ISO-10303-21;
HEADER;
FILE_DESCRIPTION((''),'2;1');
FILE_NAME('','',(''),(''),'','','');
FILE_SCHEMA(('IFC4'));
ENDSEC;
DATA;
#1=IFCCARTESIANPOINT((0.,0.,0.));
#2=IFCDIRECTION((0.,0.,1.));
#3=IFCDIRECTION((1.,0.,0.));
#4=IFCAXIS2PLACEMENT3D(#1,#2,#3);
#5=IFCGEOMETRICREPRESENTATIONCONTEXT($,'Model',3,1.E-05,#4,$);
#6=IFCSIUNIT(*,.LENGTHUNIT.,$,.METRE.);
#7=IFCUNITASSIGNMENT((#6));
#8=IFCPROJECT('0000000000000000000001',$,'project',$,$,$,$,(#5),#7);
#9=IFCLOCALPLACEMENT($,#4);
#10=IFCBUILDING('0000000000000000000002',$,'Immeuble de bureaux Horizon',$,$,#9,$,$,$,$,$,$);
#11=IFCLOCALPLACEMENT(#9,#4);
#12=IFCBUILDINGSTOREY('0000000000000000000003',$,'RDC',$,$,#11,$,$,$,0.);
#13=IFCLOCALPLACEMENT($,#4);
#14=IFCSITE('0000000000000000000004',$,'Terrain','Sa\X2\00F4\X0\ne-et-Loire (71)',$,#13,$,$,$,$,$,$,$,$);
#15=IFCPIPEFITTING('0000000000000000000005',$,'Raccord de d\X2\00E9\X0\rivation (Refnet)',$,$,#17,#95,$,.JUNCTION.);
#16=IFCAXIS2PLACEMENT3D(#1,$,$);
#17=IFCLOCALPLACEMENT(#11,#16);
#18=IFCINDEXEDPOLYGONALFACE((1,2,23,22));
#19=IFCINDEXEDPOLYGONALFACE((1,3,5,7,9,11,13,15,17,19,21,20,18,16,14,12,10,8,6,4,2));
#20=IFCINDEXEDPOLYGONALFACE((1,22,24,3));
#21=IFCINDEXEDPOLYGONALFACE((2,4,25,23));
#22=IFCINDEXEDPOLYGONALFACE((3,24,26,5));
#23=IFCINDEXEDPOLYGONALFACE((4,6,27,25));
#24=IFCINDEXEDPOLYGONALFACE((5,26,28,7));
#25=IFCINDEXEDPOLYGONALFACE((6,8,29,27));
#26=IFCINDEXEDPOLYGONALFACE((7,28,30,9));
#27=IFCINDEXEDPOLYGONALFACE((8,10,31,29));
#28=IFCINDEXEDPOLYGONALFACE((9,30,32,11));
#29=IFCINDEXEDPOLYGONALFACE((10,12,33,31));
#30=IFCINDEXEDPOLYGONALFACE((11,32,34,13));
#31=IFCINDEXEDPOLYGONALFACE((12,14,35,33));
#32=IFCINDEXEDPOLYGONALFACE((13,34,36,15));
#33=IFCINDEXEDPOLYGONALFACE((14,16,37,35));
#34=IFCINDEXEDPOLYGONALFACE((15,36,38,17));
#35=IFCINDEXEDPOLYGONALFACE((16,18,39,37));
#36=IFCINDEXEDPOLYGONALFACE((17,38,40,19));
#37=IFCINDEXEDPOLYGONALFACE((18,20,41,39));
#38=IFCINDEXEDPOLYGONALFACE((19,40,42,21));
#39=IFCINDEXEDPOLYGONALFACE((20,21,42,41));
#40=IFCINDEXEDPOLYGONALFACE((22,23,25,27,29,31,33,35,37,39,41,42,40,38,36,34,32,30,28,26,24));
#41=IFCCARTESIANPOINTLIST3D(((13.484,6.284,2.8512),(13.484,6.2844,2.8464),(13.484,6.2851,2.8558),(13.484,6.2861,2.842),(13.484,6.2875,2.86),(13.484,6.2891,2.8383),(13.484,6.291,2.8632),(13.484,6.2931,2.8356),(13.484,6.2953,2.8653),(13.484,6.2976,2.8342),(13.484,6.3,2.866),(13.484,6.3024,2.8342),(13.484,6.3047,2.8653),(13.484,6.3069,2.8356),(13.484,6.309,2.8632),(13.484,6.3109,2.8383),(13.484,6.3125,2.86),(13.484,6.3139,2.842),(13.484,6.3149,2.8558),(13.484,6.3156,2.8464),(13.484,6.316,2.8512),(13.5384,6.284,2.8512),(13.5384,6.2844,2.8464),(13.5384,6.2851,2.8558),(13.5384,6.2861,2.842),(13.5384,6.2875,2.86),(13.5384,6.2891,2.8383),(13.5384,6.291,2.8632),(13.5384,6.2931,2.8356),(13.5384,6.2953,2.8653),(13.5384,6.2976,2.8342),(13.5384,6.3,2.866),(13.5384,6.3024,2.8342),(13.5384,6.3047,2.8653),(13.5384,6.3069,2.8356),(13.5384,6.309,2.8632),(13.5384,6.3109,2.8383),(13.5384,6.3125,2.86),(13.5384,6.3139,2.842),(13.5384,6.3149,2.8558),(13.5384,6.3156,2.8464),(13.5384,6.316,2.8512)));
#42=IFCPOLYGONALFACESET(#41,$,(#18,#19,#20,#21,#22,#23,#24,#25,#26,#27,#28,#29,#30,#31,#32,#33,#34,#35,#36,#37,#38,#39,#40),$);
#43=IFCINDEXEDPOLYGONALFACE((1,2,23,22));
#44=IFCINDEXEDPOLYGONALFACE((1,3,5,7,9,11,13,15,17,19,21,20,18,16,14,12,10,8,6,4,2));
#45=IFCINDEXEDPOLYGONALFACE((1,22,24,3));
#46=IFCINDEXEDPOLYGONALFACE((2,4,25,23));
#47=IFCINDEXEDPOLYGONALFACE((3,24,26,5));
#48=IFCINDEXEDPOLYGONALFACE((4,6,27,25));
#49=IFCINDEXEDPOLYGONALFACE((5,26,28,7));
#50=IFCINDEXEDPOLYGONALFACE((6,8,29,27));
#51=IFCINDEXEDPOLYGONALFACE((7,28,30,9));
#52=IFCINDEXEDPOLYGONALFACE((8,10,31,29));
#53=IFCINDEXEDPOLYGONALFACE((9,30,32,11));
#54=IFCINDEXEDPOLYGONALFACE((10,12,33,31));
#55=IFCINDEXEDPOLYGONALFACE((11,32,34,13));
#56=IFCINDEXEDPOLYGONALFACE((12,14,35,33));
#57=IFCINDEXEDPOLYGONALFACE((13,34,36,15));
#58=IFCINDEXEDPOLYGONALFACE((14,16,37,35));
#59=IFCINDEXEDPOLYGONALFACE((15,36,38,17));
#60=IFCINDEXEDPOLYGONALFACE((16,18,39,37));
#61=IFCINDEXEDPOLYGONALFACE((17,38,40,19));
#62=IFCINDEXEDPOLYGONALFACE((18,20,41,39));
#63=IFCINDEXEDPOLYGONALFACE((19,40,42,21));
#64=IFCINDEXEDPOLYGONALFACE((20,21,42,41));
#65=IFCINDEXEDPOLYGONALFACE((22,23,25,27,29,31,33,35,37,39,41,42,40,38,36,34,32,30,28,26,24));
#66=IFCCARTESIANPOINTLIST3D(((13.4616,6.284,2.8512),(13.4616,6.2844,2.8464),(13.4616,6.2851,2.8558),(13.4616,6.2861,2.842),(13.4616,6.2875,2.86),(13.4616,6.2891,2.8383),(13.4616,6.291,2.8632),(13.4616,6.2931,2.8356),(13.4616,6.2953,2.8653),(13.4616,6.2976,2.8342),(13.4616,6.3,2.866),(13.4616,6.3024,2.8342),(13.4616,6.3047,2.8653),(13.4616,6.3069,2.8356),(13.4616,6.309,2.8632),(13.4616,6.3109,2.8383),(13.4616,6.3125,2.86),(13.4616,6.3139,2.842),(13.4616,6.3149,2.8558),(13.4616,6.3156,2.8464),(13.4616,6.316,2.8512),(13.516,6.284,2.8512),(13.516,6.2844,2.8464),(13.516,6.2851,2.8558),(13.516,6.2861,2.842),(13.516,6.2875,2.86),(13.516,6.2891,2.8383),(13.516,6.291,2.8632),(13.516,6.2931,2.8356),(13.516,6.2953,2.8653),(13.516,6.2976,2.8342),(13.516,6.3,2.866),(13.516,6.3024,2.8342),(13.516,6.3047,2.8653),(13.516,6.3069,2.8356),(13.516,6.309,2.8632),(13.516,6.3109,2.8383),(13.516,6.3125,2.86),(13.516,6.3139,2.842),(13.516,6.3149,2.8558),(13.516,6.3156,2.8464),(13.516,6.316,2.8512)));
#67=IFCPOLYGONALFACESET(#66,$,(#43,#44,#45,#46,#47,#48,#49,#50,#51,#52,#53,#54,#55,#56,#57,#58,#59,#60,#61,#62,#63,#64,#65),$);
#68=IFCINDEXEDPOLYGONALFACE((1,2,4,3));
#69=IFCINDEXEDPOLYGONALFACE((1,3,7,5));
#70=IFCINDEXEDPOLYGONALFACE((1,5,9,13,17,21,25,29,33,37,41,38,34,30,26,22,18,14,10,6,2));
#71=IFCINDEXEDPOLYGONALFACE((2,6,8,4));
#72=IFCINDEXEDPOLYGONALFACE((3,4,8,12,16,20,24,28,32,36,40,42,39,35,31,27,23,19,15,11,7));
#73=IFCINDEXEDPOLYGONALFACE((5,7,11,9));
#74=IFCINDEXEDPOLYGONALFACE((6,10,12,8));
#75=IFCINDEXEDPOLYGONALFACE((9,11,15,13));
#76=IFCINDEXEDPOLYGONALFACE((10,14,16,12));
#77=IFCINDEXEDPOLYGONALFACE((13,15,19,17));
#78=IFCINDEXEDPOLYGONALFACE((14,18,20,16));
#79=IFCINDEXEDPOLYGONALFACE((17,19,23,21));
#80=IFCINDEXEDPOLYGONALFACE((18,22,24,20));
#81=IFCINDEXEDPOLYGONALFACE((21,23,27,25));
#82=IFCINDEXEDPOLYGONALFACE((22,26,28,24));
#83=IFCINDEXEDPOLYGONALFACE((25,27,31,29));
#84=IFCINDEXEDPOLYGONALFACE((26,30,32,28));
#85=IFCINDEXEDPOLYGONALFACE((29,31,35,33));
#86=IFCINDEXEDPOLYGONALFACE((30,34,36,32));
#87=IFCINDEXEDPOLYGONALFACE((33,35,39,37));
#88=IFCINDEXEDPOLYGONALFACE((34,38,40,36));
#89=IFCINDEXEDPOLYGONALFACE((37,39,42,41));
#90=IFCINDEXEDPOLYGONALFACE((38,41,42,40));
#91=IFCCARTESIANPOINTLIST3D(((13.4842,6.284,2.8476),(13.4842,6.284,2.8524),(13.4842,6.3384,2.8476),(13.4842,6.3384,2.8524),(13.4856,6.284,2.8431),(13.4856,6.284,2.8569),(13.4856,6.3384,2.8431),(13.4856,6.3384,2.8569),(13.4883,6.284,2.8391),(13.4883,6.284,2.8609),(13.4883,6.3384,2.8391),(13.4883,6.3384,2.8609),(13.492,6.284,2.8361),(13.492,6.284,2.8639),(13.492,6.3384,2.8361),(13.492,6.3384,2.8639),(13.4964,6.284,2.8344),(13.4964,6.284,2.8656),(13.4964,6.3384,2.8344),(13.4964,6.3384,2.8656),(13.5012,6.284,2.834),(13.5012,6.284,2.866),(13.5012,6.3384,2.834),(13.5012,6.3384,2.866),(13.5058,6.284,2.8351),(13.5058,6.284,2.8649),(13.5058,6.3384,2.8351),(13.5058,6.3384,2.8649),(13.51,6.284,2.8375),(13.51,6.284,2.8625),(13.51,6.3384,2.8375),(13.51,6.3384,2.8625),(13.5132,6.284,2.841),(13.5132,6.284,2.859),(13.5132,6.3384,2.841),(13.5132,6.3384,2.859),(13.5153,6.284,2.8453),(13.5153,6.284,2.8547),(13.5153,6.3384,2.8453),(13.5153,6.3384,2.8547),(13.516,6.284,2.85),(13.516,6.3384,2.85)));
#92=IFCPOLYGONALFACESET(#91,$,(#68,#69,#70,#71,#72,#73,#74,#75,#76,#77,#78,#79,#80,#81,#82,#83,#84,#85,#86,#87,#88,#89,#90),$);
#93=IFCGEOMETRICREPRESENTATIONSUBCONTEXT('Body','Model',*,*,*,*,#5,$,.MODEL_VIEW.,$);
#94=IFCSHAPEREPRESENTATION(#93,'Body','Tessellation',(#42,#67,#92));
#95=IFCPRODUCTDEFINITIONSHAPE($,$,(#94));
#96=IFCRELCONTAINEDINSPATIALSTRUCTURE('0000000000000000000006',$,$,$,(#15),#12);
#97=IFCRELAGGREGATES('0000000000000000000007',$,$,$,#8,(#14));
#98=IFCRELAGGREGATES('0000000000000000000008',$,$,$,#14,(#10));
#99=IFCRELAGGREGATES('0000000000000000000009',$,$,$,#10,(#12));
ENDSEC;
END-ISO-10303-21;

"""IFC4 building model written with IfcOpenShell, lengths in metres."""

from ifc_helpers import new_model, si_unit, frame, origin_with_axes, place, context, subcontext, project, spatial, circle, extrude, element, save


model = new_model("IFC4")

# Units and contexts
model_context = context("Model", 3, precision=1e-05, world=origin_with_axes())
body_context = subcontext(model_context, "Body", "Model", "MODEL_VIEW")
ifc_project = project(units=[si_unit("LENGTHUNIT", "METRE")], contexts=[model_context])

# Site, building, storey
site_placement = place(None, origin_with_axes())
site = spatial("IfcSite", under=ifc_project, at=site_placement, Name="Terrain", Description="Saône-et-Loire (71)")
building_placement = place(None, origin_with_axes())
building = spatial("IfcBuilding", under=site, at=building_placement, Name="Immeuble de bureaux Horizon")
storey_placement = place(building_placement, origin_with_axes())
storey = spatial("IfcBuildingStorey", under=building, at=storey_placement, Name="RDC", Elevation=0.0)

# Pipe fitting
for number, where, z_axis, x_axis, name in (
    (1, (13.5, 6.3, 2.85), (0.0, 0.0, 1.0), (1.0, 0.0, 0.0), "Raccord de dérivation (Refnet)"),
):
    element("IfcPipeFitting", number, at=place(storey_placement, frame(where, z_axis=z_axis, x_axis=x_axis)), inside=storey, Name=name, PredefinedType="JUNCTION", context=body_context, shape_type="SweptSolid", body=[
        extrude(circle(Radius=0.016), frame((-0.016, 0.0, 0.0), z_axis=(1.0, 0.0, 0.0), x_axis=(0.0, 0.0, 1.0)), (0.0, 0.0, 1.0), 0.0544),
        extrude(circle(Radius=0.016), frame((0.016, 0.0, 0.0), z_axis=(-1.0, 0.0, 0.0), x_axis=(0.0, 0.0, 1.0)), (0.0, 0.0, 1.0), 0.0544),
        extrude(circle(Radius=0.016), frame((0.0, -0.016, 0.0), z_axis=(0.0, 1.0, 0.0), x_axis=(1.0, 0.0, 0.0)), (0.0, 0.0, 1.0), 0.0544),
    ])

save(model, "model.ifc")
